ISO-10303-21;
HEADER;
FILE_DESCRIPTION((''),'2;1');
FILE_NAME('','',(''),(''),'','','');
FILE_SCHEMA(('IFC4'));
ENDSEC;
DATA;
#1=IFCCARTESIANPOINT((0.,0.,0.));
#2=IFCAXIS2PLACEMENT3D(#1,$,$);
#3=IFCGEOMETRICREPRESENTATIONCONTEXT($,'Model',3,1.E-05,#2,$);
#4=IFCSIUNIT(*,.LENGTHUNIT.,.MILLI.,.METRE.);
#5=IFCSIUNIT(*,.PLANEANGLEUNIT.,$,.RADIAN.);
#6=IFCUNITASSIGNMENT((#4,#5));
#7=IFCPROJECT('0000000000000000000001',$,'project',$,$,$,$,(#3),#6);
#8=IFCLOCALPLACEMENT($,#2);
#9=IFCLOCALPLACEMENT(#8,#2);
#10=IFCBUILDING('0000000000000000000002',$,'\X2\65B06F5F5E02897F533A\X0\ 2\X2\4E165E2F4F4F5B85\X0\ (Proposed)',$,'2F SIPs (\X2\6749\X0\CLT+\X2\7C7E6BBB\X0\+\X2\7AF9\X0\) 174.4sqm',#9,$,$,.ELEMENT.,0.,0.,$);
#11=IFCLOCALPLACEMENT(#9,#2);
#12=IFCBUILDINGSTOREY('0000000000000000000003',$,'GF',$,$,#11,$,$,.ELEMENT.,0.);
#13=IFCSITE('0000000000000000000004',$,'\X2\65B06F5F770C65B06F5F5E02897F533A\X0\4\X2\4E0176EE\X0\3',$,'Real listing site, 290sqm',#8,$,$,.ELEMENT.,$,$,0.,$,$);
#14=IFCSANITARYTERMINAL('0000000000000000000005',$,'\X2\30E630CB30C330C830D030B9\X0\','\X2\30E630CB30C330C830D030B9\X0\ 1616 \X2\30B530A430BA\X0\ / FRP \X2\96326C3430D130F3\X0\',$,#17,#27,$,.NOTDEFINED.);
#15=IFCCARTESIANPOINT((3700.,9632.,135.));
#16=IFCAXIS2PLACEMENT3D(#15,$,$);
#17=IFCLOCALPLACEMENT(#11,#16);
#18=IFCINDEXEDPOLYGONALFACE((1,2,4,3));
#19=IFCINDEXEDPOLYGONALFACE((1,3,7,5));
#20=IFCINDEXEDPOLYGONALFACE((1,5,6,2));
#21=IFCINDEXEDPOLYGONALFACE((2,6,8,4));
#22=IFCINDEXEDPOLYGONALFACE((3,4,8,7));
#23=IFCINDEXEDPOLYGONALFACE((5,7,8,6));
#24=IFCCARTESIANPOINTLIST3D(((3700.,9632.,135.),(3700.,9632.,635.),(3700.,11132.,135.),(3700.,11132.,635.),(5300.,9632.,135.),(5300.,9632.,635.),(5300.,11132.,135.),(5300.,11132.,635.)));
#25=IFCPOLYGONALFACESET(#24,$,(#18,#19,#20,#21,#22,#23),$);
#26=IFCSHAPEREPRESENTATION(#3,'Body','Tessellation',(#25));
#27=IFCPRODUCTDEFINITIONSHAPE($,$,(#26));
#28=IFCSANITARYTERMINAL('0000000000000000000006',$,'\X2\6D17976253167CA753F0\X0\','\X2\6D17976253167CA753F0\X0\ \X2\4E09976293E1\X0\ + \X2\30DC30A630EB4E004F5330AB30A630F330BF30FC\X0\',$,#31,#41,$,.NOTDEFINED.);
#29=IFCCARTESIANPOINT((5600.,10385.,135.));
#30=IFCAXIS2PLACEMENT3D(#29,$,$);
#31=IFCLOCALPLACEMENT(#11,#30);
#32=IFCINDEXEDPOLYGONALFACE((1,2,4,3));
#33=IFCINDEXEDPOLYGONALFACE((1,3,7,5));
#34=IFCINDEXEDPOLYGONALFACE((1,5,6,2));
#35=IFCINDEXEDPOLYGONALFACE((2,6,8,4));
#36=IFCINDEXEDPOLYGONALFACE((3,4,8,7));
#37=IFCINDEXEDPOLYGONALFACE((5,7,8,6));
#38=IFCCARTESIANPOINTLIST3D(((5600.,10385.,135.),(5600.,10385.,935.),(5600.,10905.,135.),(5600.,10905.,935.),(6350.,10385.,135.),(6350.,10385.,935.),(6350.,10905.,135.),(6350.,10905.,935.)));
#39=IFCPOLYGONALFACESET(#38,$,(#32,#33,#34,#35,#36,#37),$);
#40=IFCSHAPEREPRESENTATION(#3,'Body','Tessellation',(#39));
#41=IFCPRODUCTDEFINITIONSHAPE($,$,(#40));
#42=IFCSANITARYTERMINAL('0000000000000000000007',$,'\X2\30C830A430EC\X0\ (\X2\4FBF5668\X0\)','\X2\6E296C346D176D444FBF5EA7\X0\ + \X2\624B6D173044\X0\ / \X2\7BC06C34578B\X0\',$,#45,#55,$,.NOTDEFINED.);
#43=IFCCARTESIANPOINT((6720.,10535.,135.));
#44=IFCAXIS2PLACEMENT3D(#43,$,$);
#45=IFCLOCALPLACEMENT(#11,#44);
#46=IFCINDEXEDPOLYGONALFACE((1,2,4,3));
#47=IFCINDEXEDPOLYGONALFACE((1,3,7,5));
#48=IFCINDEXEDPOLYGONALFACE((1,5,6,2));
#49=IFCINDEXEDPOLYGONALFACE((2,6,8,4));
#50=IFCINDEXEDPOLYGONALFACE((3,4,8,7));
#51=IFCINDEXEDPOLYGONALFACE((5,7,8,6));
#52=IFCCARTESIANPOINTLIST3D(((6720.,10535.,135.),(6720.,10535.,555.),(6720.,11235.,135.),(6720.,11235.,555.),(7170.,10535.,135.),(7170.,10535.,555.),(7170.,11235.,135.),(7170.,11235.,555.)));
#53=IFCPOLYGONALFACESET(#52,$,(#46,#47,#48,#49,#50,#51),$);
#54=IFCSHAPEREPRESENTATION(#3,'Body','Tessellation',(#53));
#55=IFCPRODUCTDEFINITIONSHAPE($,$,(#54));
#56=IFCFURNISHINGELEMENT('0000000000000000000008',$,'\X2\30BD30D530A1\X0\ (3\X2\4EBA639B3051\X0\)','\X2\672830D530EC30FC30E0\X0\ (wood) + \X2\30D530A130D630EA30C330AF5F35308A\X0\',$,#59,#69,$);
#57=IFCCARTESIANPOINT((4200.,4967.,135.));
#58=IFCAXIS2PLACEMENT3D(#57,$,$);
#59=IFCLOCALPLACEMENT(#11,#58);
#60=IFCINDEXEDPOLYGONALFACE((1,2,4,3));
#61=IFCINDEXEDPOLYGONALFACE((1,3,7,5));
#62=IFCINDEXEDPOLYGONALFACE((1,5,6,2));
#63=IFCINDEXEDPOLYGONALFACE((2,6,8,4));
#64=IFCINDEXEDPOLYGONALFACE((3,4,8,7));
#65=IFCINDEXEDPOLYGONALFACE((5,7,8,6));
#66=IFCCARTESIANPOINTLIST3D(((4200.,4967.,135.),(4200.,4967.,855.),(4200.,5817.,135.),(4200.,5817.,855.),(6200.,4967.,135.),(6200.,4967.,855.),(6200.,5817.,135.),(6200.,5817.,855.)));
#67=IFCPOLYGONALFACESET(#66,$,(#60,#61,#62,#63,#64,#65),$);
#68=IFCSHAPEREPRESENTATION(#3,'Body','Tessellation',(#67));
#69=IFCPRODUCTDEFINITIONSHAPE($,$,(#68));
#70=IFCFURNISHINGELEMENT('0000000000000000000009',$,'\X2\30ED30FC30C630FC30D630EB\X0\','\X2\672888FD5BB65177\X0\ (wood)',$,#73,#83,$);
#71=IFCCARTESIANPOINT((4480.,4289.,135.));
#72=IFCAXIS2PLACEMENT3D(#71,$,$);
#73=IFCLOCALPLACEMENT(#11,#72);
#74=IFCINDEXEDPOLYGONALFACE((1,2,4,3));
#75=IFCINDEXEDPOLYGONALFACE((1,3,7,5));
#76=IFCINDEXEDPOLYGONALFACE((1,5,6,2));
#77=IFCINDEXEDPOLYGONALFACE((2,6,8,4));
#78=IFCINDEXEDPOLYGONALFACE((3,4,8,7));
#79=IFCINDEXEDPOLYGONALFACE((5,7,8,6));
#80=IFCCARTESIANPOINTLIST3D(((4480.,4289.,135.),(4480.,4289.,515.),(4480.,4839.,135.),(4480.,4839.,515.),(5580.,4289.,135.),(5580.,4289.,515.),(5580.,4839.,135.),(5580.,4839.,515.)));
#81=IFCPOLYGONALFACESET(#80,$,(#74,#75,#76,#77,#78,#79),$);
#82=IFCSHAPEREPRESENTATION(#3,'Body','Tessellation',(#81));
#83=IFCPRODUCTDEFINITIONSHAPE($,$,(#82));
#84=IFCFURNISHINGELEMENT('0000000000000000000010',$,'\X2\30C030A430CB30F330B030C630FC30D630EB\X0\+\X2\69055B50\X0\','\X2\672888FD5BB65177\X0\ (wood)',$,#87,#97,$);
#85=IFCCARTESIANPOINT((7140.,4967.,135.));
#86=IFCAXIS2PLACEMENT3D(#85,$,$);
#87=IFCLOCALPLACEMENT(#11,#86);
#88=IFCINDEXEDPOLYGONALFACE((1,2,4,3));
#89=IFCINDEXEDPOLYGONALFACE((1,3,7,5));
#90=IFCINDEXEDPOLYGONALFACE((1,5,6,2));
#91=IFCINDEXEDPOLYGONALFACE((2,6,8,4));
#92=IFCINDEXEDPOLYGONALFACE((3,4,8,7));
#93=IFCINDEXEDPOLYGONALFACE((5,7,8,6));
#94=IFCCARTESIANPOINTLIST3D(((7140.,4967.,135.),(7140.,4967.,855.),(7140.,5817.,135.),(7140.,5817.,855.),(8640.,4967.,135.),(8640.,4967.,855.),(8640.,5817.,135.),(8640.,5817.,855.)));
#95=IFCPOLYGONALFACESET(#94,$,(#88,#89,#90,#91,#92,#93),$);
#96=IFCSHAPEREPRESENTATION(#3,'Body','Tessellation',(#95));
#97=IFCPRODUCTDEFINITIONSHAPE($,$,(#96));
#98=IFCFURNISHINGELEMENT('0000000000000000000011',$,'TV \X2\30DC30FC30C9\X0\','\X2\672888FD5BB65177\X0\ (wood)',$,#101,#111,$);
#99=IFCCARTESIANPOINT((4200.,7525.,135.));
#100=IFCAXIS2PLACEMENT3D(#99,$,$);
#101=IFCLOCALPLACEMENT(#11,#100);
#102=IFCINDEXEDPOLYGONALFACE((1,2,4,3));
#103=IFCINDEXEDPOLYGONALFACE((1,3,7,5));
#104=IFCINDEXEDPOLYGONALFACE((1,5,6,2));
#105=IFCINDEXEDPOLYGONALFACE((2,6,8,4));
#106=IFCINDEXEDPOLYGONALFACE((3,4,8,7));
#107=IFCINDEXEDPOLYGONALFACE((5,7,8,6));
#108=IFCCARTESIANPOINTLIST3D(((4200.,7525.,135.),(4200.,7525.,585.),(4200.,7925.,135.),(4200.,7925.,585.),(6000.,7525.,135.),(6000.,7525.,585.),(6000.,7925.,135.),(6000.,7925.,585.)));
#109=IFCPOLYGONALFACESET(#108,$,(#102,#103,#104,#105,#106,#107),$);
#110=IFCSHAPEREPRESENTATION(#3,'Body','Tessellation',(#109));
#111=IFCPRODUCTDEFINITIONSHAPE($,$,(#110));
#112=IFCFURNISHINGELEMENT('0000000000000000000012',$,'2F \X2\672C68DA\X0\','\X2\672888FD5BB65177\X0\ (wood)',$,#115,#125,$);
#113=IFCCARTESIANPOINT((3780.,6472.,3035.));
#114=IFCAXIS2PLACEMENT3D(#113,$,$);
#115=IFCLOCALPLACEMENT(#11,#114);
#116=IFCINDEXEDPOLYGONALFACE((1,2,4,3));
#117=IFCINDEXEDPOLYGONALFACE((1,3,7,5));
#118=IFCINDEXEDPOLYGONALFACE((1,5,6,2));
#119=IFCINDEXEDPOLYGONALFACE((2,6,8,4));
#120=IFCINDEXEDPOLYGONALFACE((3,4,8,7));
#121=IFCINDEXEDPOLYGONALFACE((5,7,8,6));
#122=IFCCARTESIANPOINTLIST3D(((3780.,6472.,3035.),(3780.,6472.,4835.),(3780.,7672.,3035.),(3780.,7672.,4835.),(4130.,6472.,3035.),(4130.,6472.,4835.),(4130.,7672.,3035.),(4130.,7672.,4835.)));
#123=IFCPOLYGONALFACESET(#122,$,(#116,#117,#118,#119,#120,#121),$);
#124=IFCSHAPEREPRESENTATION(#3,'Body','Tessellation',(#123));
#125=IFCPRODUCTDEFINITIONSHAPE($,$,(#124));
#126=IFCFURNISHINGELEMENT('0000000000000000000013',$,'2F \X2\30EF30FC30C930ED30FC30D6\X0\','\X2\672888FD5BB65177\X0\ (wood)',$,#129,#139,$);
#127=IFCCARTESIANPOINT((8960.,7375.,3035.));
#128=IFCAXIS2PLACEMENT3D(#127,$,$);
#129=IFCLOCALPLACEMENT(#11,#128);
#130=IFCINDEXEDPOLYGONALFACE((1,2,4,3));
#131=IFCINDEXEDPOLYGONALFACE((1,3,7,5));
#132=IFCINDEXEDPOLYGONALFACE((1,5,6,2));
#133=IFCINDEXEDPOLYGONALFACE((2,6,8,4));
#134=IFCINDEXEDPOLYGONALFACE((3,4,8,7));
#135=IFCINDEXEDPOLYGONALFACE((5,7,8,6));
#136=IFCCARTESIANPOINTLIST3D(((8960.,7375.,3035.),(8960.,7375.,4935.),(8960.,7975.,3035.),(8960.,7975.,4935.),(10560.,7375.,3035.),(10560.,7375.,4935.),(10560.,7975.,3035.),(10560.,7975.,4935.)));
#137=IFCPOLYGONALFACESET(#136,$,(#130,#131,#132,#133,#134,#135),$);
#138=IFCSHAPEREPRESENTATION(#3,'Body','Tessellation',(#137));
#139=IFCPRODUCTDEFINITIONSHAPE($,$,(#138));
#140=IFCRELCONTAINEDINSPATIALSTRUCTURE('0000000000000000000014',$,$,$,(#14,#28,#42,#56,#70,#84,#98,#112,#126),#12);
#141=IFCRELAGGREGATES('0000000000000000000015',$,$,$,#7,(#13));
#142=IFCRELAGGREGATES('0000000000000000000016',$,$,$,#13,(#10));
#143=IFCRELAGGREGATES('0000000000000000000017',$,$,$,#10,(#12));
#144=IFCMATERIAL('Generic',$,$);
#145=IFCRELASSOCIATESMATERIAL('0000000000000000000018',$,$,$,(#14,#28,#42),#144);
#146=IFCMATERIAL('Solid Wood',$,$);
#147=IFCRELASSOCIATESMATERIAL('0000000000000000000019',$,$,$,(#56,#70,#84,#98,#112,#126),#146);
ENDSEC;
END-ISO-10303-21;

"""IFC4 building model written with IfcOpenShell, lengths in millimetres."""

from ifc_helpers import new_model, si_unit, frame, frame_2d, origin, place, context, project, spatial, rectangle, extrude, material, element, save


model = new_model("IFC4")

# Units and contexts
model_context = context("Model", 3, precision=1e-05, world=origin())
ifc_project = project(units=[si_unit("LENGTHUNIT", "METRE", prefix="MILLI"), si_unit("PLANEANGLEUNIT", "RADIAN")], contexts=[model_context])

# Site, building, storey
site_placement = place(None, origin())
site = spatial("IfcSite", under=ifc_project, at=site_placement, Name="新潟県新潟市西区4丁目3", ObjectType="Real listing site, 290sqm", CompositionType="ELEMENT", RefElevation=0.0)
building_placement = place(site_placement, origin())
building = spatial("IfcBuilding", under=site, at=building_placement, Name="新潟市西区 2世帯住宅 (Proposed)", ObjectType="2F SIPs (杉CLT+籾殻+竹) 174.4sqm", CompositionType="ELEMENT", ElevationOfRefHeight=0.0, ElevationOfTerrain=0.0)
storey_placement = place(building_placement, origin())
storey = spatial("IfcBuildingStorey", under=building, at=storey_placement, Name="GF", CompositionType="ELEMENT", Elevation=0.0)

# Shared definitions
ifc_material_1 = material(Name="Generic")

# Shared definitions
ifc_material_2 = material(Name="Solid Wood")

# Sanitary terminals
sanitary_terminal_1_placement = place(storey_placement, frame((3700.0, 9632.0, 135.0)))
element("IfcSanitaryTerminal", 1, at=sanitary_terminal_1_placement, inside=storey, material=ifc_material_1, Name="ユニットバス", Description="ユニットバス 1616 サイズ / FRP 防水パン", PredefinedType="NOTDEFINED", context=model_context, shape_type="SweptSolid", body=[
    extrude(rectangle(XDim=1600.0, YDim=1500.0, at=frame_2d((800.0, 750.0))), frame((3700.0, 9632.0, 135.0)), (0.0, 0.0, 1.0), 500.0),
])
sanitary_terminal_2_placement = place(storey_placement, frame((5600.0, 10385.0, 135.0)))
element("IfcSanitaryTerminal", 2, at=sanitary_terminal_2_placement, inside=storey, material=ifc_material_1, Name="洗面化粧台", Description="洗面化粧台 三面鏡 + ボウル一体カウンター", PredefinedType="NOTDEFINED", context=model_context, shape_type="SweptSolid", body=[
    extrude(rectangle(XDim=750.0, YDim=520.0, at=frame_2d((375.0, 260.0))), frame((5600.0, 10385.0, 135.0)), (0.0, 0.0, 1.0), 800.0),
])
sanitary_terminal_3_placement = place(storey_placement, frame((6720.0, 10535.0, 135.0)))
element("IfcSanitaryTerminal", 3, at=sanitary_terminal_3_placement, inside=storey, material=ifc_material_1, Name="トイレ (便器)", Description="温水洗浄便座 + 手洗い / 節水型", PredefinedType="NOTDEFINED", context=model_context, shape_type="SweptSolid", body=[
    extrude(rectangle(XDim=450.0, YDim=700.0, at=frame_2d((225.0, 350.0))), frame((6720.0, 10535.0, 135.0)), (0.0, 0.0, 1.0), 420.0),
])

# Furnishing elements
furnishing_1_placement = place(storey_placement, frame((4200.0, 4967.0, 135.0)))
element("IfcFurnishingElement", 4, at=furnishing_1_placement, inside=storey, material=ifc_material_2, Name="ソファ (3人掛け)", Description="木フレーム (wood) + ファブリック張り", context=model_context, shape_type="SweptSolid", body=[
    extrude(rectangle(XDim=2000.0, YDim=850.0, at=frame_2d((1000.0, 425.0))), frame((4200.0, 4967.0, 135.0)), (0.0, 0.0, 1.0), 720.0),
])
furnishing_2_placement = place(storey_placement, frame((4480.0, 4289.0, 135.0)))
element("IfcFurnishingElement", 5, at=furnishing_2_placement, inside=storey, material=ifc_material_2, Name="ローテーブル", Description="木製家具 (wood)", context=model_context, shape_type="SweptSolid", body=[
    extrude(rectangle(XDim=1100.0, YDim=550.0, at=frame_2d((550.0, 275.0))), frame((4480.0, 4289.0, 135.0)), (0.0, 0.0, 1.0), 380.0),
])
furnishing_3_placement = place(storey_placement, frame((7140.0, 4967.0, 135.0)))
element("IfcFurnishingElement", 6, at=furnishing_3_placement, inside=storey, material=ifc_material_2, Name="ダイニングテーブル+椅子", Description="木製家具 (wood)", context=model_context, shape_type="SweptSolid", body=[
    extrude(rectangle(XDim=1500.0, YDim=850.0, at=frame_2d((750.0, 425.0))), frame((7140.0, 4967.0, 135.0)), (0.0, 0.0, 1.0), 720.0),
])
furnishing_4_placement = place(storey_placement, frame((4200.0, 7525.0, 135.0)))
element("IfcFurnishingElement", 7, at=furnishing_4_placement, inside=storey, material=ifc_material_2, Name="TV ボード", Description="木製家具 (wood)", context=model_context, shape_type="SweptSolid", body=[
    extrude(rectangle(XDim=1800.0, YDim=400.0, at=frame_2d((900.0, 200.0))), frame((4200.0, 7525.0, 135.0)), (0.0, 0.0, 1.0), 450.0),
])
furnishing_5_placement = place(storey_placement, frame((3780.0, 6472.0, 3035.0)))
element("IfcFurnishingElement", 8, at=furnishing_5_placement, inside=storey, material=ifc_material_2, Name="2F 本棚", Description="木製家具 (wood)", context=model_context, shape_type="SweptSolid", body=[
    extrude(rectangle(XDim=350.0, YDim=1200.0, at=frame_2d((175.0, 600.0))), frame((3780.0, 6472.0, 3035.0)), (0.0, 0.0, 1.0), 1800.0),
])
furnishing_6_placement = place(storey_placement, frame((8960.0, 7375.0, 3035.0)))
element("IfcFurnishingElement", 9, at=furnishing_6_placement, inside=storey, material=ifc_material_2, Name="2F ワードローブ", Description="木製家具 (wood)", context=model_context, shape_type="SweptSolid", body=[
    extrude(rectangle(XDim=1600.0, YDim=600.0, at=frame_2d((800.0, 300.0))), frame((8960.0, 7375.0, 3035.0)), (0.0, 0.0, 1.0), 1900.0),
])

save(model, "model.ifc")
